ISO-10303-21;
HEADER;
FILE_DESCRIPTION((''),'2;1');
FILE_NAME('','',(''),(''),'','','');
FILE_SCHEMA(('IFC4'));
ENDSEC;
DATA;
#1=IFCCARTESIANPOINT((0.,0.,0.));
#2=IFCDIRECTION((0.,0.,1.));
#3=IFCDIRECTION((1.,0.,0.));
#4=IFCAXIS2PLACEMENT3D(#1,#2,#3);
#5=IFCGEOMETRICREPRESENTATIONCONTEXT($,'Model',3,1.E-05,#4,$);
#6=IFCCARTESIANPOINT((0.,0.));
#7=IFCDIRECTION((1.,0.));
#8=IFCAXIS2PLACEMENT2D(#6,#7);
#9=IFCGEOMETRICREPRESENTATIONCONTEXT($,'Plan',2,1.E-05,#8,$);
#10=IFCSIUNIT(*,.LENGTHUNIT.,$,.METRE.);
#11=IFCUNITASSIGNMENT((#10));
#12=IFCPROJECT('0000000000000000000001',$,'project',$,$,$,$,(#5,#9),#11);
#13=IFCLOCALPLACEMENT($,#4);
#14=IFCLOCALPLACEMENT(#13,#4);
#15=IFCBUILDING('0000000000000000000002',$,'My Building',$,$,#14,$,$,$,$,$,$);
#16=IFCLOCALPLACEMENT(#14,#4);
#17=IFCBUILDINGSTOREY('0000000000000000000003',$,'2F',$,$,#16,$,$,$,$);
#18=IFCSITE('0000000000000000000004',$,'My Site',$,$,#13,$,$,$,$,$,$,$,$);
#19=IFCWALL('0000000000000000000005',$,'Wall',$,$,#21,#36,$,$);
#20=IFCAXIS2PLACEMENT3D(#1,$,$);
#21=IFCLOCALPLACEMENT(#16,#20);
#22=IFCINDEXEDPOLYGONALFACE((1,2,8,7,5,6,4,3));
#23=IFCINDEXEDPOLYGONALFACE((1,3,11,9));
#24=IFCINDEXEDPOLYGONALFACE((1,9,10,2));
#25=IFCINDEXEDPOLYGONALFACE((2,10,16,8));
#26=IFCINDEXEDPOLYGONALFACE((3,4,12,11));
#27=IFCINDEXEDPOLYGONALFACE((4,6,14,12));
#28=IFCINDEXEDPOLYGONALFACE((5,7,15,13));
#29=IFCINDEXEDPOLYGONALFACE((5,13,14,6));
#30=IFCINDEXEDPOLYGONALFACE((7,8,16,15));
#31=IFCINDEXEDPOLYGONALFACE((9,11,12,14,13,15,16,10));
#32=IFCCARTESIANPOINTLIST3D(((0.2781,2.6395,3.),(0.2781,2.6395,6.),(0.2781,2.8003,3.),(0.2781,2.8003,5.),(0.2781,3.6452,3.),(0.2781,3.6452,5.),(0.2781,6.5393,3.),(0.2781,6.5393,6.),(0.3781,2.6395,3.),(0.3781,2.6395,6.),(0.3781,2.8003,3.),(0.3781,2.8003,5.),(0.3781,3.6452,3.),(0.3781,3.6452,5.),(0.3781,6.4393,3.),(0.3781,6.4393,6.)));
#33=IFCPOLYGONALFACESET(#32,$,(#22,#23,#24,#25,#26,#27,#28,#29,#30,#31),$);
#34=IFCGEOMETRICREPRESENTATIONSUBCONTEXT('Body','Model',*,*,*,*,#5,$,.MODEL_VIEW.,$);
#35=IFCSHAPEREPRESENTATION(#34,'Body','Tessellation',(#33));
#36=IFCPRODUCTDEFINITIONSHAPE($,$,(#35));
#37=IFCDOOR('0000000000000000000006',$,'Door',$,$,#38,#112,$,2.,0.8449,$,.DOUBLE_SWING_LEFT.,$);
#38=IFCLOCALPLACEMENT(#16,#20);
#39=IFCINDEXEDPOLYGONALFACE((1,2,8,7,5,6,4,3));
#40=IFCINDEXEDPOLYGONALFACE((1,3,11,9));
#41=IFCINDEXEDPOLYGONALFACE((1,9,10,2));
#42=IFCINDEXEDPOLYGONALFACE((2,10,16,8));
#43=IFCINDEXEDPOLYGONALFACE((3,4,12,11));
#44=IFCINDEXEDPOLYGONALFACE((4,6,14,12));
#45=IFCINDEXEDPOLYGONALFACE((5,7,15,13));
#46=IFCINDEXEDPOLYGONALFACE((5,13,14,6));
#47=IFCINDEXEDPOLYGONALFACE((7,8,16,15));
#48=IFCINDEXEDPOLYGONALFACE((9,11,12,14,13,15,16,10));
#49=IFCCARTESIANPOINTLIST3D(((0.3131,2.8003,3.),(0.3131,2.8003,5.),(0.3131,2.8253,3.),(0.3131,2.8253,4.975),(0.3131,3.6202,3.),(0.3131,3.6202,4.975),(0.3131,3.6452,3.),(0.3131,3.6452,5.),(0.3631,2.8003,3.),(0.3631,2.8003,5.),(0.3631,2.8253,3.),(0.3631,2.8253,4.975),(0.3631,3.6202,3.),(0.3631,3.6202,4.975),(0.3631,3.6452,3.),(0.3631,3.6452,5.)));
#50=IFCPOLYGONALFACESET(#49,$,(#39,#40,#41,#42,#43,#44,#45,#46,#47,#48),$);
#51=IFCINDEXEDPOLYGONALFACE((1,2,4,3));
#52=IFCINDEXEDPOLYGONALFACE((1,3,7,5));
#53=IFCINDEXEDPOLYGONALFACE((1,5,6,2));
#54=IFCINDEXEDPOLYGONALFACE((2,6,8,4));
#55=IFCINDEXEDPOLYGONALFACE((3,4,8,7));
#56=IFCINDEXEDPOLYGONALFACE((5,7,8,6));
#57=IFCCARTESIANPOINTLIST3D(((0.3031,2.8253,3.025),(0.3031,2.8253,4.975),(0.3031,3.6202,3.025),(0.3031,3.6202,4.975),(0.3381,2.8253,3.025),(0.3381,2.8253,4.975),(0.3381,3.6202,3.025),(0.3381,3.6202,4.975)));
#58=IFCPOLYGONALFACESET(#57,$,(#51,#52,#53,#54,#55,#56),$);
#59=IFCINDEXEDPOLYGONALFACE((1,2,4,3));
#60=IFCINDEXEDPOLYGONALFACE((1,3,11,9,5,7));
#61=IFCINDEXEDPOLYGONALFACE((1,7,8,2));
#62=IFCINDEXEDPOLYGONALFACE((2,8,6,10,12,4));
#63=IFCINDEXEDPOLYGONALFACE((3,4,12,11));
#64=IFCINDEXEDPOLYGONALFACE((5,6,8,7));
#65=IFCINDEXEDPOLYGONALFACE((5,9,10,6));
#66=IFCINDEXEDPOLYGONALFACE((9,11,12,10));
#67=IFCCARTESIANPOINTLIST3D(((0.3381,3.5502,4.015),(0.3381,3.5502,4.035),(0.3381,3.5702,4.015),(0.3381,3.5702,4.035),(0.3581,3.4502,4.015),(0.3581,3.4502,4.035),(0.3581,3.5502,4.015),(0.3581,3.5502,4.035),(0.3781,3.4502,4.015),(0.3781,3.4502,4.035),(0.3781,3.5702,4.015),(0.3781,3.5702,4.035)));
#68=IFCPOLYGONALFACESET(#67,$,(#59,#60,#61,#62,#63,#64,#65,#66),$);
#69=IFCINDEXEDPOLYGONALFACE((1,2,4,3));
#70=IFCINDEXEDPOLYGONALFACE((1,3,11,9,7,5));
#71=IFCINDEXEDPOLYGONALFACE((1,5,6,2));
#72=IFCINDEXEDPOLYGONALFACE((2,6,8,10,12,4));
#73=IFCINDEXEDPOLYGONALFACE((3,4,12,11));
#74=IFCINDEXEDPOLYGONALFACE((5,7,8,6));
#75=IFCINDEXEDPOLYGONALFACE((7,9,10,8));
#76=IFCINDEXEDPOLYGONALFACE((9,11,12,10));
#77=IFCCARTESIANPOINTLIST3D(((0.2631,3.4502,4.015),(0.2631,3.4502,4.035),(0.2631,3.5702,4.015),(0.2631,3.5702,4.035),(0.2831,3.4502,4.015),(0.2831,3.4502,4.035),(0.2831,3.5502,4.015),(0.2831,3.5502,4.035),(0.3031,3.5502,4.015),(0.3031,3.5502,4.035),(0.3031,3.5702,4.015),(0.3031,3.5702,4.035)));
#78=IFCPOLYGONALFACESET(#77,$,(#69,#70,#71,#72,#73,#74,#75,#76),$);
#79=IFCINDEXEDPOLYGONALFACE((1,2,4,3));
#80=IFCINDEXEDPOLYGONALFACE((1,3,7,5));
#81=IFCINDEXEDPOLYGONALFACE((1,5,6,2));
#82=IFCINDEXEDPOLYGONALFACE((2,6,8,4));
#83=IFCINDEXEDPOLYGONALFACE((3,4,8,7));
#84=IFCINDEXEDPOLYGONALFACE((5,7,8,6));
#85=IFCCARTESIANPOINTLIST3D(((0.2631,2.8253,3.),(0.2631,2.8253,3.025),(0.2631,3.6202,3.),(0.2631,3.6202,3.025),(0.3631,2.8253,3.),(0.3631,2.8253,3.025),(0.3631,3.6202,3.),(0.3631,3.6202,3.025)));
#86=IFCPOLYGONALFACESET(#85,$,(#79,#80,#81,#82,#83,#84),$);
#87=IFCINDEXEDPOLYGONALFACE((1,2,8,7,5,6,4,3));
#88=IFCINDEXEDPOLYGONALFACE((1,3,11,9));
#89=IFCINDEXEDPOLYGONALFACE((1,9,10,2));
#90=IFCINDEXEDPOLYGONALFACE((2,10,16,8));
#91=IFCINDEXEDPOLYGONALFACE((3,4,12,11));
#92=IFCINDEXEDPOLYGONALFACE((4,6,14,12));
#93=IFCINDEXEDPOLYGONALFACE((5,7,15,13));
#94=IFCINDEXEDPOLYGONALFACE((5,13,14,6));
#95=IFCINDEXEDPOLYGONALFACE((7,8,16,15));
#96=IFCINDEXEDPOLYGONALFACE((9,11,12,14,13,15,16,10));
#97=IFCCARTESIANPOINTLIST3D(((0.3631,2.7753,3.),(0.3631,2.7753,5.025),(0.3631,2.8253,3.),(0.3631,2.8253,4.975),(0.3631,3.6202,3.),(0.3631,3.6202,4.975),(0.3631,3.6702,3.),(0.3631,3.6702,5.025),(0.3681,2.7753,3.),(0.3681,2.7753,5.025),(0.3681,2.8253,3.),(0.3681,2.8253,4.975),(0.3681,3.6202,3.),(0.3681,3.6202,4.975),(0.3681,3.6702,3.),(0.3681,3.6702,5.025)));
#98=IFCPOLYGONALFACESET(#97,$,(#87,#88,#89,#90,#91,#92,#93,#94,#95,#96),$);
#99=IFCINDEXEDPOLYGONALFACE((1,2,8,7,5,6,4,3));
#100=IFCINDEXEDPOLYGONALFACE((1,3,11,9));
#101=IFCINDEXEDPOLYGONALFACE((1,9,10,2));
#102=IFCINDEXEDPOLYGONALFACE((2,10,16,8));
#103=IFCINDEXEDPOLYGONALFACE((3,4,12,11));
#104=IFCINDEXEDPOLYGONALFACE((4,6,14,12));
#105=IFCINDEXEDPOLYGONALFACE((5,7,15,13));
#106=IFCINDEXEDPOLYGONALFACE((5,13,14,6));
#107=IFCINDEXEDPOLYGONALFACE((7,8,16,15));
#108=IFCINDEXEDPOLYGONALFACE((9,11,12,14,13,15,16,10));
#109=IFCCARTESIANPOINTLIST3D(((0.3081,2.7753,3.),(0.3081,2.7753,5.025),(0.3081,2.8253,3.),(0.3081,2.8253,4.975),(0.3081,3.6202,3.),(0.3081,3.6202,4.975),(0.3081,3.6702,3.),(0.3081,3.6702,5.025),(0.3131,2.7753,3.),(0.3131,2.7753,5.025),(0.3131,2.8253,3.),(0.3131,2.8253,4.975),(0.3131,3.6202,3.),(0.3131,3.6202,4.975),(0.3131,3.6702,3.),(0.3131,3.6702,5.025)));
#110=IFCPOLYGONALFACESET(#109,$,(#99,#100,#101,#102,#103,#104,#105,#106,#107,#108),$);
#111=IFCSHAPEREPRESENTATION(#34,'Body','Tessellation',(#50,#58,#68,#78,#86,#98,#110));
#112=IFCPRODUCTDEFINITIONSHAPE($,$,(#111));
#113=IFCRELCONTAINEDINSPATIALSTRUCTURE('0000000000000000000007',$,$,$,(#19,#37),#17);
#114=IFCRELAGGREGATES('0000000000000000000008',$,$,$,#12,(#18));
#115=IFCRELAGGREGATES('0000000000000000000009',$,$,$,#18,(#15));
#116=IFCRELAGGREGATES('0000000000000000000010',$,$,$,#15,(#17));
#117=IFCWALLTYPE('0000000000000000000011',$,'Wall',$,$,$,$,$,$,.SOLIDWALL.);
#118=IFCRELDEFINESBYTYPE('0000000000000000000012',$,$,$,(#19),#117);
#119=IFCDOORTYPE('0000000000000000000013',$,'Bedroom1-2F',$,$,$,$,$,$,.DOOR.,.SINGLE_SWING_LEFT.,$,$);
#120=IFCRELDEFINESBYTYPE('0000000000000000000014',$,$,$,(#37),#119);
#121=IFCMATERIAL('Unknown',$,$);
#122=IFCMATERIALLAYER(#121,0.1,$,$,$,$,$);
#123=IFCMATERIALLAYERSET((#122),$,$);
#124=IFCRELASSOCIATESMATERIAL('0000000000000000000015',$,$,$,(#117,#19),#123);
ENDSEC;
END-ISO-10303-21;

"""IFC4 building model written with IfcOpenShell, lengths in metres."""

from ifc_helpers import new_model, entity, si_unit, frame, origin_with_axes, origin_2d_with_axis, place, context, subcontext, project, spatial, line, indexed_curve, outline, extrude, shape, source, transform, mapped, material, layer, layer_set, layer_usage, type_object, type_shapes, element, fill, save


model = new_model("IFC4")

# Units and contexts
model_context = context("Model", 3, precision=1e-05, world=origin_with_axes())
plan_context = context("Plan", 2, precision=1e-05, world=origin_2d_with_axis())
body_context_1 = subcontext(model_context, "Body", "Model", "MODEL_VIEW")
body_context_2 = subcontext(plan_context, "Body", "Plan", "PLAN_VIEW")
ifc_project = project(units=[si_unit("LENGTHUNIT", "METRE")], contexts=[model_context, plan_context])

# Site, building, storey
site_placement = place(None, origin_with_axes())
site = spatial("IfcSite", under=ifc_project, at=site_placement, Name="My Site")
building_placement = place(site_placement, origin_with_axes())
building = spatial("IfcBuilding", under=site, at=building_placement, Name="My Building")
storey_placement = place(building_placement, origin_with_axes())
storey = spatial("IfcBuildingStorey", under=building, at=storey_placement, Name="2F")

# Shared definitions
ifc_material = material(Name="Unknown")

# Shared definitions
ifc_layer = layer(ifc_material, 0.1)
ifc_layer_set = layer_set([ifc_layer])
wall_type = type_object("IfcWallType", Name="Wall", PredefinedType="SOLIDWALL", material=ifc_layer_set)

# Wall, opening, door
ifc_layer_usage_1 = layer_usage(ifc_layer_set, "AXIS2", "POSITIVE", 0.0)
wall_1_placement = place(storey_placement, frame((0.2781, 6.5393, 3.0), z_axis=(0.0, 0.0, 1.0), x_axis=(0.0, -1.0, 0.0)))
wall_1 = element("IfcWall", 1, at=wall_1_placement, inside=storey, type_object=wall_type, material=ifc_layer_usage_1, Name="Wall", context=body_context_1, shape_type="SweptSolid", body=[
    extrude(outline(indexed_curve([(0.0, 0.0), (0.1, 0.1), (3.8998, 0.1), (3.8998, 0.0)], segments=[line(1, 2, 3, 4, 1)])), origin_with_axes(), (0.0, 0.0, 1.0), 3.0),
])
shared_shape_1 = source(origin_with_axes(), body_context_1, "Body", "SweptSolid", [
    extrude(outline(indexed_curve([(0.0, 0.0), (0.8449, 0.0), (0.8449, 2.0), (0.0, 2.0)], segments=[line(1, 2, 3, 4, 1)])), frame((0.0, -0.6, 0.0), z_axis=(0.0, -1.0, 0.0), x_axis=(1.0, 0.0, 0.0)), (0.0, 0.0, -1.0), 1.2),
])
opening_1_placement = place(wall_1_placement, frame((3.739, 0.085, 0.0), z_axis=(0.0, 0.0, 1.0), x_axis=(-1.0, 0.0, 0.0)))
opening_1 = element("IfcOpeningElement", 2, at=opening_1_placement, cuts=wall_1, PredefinedType="OPENING", context=body_context_1, shape_type="MappedRepresentation", body=[
    mapped(shared_shape_1, transform((0.0, 0.0, 0.0), x_axis=(1.0, 0.0, 0.0), y_axis=(0.0, 1.0, 0.0), z_axis=(0.0, 0.0, 1.0), scale=1.0)),
])
door_type_1 = type_object("IfcDoorType", Name="Bedroom1-2F", OperationType="SINGLE_SWING_LEFT", PredefinedType="DOOR")
shared_shape_2 = source(origin_with_axes(), body_context_1, "Body", "SweptSolid", [
    extrude(outline(indexed_curve([(0.0, 0.0), (0.0, 2.0), (0.8449, 2.0), (0.8449, 0.0), (0.8199, 0.0), (0.8199, 1.975), (0.025, 1.975), (0.025, 0.0)], segments=[line(1, 2, 3, 4, 5, 6, 7, 8, 1)])), frame((0.0, 0.0, 0.0), z_axis=(0.0, -1.0, 0.0), x_axis=(1.0, 0.0, 0.0)), (0.0, 0.0, -1.0), 0.05),
    extrude(outline(indexed_curve([(0.0, 0.0), (0.7949, 0.0), (0.7949, 0.035), (0.0, 0.035)], segments=[line(1, 2, 3, 4, 1)])), frame((0.025, 0.025, 0.025), z_axis=(0.0, 0.0, 1.0), x_axis=(1.0, 0.0, 0.0)), (0.0, 0.0, 1.0), 1.95),
    extrude(outline(indexed_curve([(0.0, 0.0), (0.0, -0.04), (-0.12, -0.04), (-0.12, -0.02), (-0.02, -0.02), (-0.02, 0.0)], segments=[line(1, 2, 3, 4, 5, 6, 1)])), frame((0.7699, 0.025, 1.015), z_axis=(0.0, 0.0, 1.0), x_axis=(1.0, 0.0, 0.0)), (0.0, 0.0, 1.0), 0.02),
    extrude(outline(indexed_curve([(0.0, 0.0), (0.0, 0.04), (-0.12, 0.04), (-0.12, 0.02), (-0.02, 0.02), (-0.02, 0.0)], segments=[line(1, 2, 3, 4, 5, 6, 1)])), frame((0.7699, 0.06, 1.015), z_axis=(0.0, 0.0, 1.0), x_axis=(1.0, 0.0, 0.0)), (0.0, 0.0, 1.0), 0.02),
    extrude(outline(indexed_curve([(0.0, 0.0), (0.7949, 0.0), (0.7949, 0.1), (0.0, 0.1)], segments=[line(1, 2, 3, 4, 1)])), frame((0.025, 0.0, 0.0), z_axis=(0.0, 0.0, 1.0), x_axis=(1.0, 0.0, 0.0)), (0.0, 0.0, 1.0), 0.025),
    extrude(outline(indexed_curve([(0.0, 0.0), (0.0, 2.025), (0.8949, 2.025), (0.8949, 0.0), (0.8449, 0.0), (0.8449, 1.975), (0.05, 1.975), (0.05, 0.0)], segments=[line(1, 2, 3, 4, 5, 6, 7, 8, 1)])), frame((-0.025, -0.005, 0.0), z_axis=(0.0, -1.0, 0.0), x_axis=(1.0, 0.0, 0.0)), (0.0, 0.0, -1.0), 0.005),
    extrude(outline(indexed_curve([(0.0, 0.0), (0.0, 2.025), (0.8949, 2.025), (0.8949, 0.0), (0.8449, 0.0), (0.8449, 1.975), (0.05, 1.975), (0.05, 0.0)], segments=[line(1, 2, 3, 4, 5, 6, 7, 8, 1)])), frame((-0.025, 0.05, 0.0), z_axis=(0.0, -1.0, 0.0), x_axis=(1.0, 0.0, 0.0)), (0.0, 0.0, -1.0), 0.005),
])
shared_shape_3 = source(origin_with_axes(), body_context_2, "Body", "Curve2D", [
    entity("IfcIndexedPolyCurve", entity("IfcCartesianPointList2D", [[0.0, 0.0], [0.025, 0.0], [0.025, 0.05], [0.0, 0.05]]), [entity("IfcLineIndex", [1, 2, 3, 4, 1])]),
    entity("IfcIndexedPolyCurve", entity("IfcCartesianPointList2D", [[0.8449, 0.0], [0.8199, 0.0], [0.8199, 0.05], [0.8449, 0.05]]), [entity("IfcLineIndex", [1, 2, 3, 4, 1])]),
    entity("IfcIndexedPolyCurve", entity("IfcCartesianPointList2D", [[0.025, 0.05], [0.025, -0.7449], [0.06, -0.7449]])),
    entity("IfcTrimmedCurve", entity("IfcEllipse", entity("IfcAxis2Placement2D", entity("IfcCartesianPoint", [0.06, 0.05]), entity("IfcDirection", [1.0, 0.0])), 0.7599, 0.7949), [entity("IfcCartesianPoint", [0.06, -0.7449])], [entity("IfcCartesianPoint", [0.06, 0.8449])], True, "CARTESIAN"),
    entity("IfcIndexedPolyCurve", entity("IfcCartesianPointList2D", [[0.025, 0.05], [0.06, 0.05], [0.06, 0.8449], [0.025, 0.8449]]), [entity("IfcLineIndex", [1, 2, 3, 4, 1])]),
])
type_shapes(door_type_1, [shared_shape_2, shared_shape_3])
door_1_placement = place(opening_1_placement, frame((0.0, 0.0, 0.0), z_axis=(0.0, 0.0, 1.0), x_axis=(1.0, 0.0, 0.0)))
door_1 = element("IfcDoor", 3, at=door_1_placement, inside=storey, type_object=door_type_1, Name="Door", OperationType="DOUBLE_SWING_LEFT", OverallHeight=2.0, OverallWidth=0.8449, shapes=[
    shape(body_context_1, "Body", "MappedRepresentation", [mapped(shared_shape_2, transform((0.0, 0.0, 0.0), x_axis=(1.0, 0.0, 0.0), y_axis=(0.0, 1.0, 0.0), z_axis=(0.0, 0.0, 1.0), scale=1.0))]),
    shape(body_context_2, "Body", "MappedRepresentation", [mapped(shared_shape_3, transform((0.0, 0.0, 0.0), x_axis=(1.0, 0.0, 0.0), y_axis=(0.0, 1.0, 0.0), z_axis=(0.0, 0.0, 1.0), scale=1.0))]),
])
fill(opening_1, door_1)

save(model, "model.ifc")
